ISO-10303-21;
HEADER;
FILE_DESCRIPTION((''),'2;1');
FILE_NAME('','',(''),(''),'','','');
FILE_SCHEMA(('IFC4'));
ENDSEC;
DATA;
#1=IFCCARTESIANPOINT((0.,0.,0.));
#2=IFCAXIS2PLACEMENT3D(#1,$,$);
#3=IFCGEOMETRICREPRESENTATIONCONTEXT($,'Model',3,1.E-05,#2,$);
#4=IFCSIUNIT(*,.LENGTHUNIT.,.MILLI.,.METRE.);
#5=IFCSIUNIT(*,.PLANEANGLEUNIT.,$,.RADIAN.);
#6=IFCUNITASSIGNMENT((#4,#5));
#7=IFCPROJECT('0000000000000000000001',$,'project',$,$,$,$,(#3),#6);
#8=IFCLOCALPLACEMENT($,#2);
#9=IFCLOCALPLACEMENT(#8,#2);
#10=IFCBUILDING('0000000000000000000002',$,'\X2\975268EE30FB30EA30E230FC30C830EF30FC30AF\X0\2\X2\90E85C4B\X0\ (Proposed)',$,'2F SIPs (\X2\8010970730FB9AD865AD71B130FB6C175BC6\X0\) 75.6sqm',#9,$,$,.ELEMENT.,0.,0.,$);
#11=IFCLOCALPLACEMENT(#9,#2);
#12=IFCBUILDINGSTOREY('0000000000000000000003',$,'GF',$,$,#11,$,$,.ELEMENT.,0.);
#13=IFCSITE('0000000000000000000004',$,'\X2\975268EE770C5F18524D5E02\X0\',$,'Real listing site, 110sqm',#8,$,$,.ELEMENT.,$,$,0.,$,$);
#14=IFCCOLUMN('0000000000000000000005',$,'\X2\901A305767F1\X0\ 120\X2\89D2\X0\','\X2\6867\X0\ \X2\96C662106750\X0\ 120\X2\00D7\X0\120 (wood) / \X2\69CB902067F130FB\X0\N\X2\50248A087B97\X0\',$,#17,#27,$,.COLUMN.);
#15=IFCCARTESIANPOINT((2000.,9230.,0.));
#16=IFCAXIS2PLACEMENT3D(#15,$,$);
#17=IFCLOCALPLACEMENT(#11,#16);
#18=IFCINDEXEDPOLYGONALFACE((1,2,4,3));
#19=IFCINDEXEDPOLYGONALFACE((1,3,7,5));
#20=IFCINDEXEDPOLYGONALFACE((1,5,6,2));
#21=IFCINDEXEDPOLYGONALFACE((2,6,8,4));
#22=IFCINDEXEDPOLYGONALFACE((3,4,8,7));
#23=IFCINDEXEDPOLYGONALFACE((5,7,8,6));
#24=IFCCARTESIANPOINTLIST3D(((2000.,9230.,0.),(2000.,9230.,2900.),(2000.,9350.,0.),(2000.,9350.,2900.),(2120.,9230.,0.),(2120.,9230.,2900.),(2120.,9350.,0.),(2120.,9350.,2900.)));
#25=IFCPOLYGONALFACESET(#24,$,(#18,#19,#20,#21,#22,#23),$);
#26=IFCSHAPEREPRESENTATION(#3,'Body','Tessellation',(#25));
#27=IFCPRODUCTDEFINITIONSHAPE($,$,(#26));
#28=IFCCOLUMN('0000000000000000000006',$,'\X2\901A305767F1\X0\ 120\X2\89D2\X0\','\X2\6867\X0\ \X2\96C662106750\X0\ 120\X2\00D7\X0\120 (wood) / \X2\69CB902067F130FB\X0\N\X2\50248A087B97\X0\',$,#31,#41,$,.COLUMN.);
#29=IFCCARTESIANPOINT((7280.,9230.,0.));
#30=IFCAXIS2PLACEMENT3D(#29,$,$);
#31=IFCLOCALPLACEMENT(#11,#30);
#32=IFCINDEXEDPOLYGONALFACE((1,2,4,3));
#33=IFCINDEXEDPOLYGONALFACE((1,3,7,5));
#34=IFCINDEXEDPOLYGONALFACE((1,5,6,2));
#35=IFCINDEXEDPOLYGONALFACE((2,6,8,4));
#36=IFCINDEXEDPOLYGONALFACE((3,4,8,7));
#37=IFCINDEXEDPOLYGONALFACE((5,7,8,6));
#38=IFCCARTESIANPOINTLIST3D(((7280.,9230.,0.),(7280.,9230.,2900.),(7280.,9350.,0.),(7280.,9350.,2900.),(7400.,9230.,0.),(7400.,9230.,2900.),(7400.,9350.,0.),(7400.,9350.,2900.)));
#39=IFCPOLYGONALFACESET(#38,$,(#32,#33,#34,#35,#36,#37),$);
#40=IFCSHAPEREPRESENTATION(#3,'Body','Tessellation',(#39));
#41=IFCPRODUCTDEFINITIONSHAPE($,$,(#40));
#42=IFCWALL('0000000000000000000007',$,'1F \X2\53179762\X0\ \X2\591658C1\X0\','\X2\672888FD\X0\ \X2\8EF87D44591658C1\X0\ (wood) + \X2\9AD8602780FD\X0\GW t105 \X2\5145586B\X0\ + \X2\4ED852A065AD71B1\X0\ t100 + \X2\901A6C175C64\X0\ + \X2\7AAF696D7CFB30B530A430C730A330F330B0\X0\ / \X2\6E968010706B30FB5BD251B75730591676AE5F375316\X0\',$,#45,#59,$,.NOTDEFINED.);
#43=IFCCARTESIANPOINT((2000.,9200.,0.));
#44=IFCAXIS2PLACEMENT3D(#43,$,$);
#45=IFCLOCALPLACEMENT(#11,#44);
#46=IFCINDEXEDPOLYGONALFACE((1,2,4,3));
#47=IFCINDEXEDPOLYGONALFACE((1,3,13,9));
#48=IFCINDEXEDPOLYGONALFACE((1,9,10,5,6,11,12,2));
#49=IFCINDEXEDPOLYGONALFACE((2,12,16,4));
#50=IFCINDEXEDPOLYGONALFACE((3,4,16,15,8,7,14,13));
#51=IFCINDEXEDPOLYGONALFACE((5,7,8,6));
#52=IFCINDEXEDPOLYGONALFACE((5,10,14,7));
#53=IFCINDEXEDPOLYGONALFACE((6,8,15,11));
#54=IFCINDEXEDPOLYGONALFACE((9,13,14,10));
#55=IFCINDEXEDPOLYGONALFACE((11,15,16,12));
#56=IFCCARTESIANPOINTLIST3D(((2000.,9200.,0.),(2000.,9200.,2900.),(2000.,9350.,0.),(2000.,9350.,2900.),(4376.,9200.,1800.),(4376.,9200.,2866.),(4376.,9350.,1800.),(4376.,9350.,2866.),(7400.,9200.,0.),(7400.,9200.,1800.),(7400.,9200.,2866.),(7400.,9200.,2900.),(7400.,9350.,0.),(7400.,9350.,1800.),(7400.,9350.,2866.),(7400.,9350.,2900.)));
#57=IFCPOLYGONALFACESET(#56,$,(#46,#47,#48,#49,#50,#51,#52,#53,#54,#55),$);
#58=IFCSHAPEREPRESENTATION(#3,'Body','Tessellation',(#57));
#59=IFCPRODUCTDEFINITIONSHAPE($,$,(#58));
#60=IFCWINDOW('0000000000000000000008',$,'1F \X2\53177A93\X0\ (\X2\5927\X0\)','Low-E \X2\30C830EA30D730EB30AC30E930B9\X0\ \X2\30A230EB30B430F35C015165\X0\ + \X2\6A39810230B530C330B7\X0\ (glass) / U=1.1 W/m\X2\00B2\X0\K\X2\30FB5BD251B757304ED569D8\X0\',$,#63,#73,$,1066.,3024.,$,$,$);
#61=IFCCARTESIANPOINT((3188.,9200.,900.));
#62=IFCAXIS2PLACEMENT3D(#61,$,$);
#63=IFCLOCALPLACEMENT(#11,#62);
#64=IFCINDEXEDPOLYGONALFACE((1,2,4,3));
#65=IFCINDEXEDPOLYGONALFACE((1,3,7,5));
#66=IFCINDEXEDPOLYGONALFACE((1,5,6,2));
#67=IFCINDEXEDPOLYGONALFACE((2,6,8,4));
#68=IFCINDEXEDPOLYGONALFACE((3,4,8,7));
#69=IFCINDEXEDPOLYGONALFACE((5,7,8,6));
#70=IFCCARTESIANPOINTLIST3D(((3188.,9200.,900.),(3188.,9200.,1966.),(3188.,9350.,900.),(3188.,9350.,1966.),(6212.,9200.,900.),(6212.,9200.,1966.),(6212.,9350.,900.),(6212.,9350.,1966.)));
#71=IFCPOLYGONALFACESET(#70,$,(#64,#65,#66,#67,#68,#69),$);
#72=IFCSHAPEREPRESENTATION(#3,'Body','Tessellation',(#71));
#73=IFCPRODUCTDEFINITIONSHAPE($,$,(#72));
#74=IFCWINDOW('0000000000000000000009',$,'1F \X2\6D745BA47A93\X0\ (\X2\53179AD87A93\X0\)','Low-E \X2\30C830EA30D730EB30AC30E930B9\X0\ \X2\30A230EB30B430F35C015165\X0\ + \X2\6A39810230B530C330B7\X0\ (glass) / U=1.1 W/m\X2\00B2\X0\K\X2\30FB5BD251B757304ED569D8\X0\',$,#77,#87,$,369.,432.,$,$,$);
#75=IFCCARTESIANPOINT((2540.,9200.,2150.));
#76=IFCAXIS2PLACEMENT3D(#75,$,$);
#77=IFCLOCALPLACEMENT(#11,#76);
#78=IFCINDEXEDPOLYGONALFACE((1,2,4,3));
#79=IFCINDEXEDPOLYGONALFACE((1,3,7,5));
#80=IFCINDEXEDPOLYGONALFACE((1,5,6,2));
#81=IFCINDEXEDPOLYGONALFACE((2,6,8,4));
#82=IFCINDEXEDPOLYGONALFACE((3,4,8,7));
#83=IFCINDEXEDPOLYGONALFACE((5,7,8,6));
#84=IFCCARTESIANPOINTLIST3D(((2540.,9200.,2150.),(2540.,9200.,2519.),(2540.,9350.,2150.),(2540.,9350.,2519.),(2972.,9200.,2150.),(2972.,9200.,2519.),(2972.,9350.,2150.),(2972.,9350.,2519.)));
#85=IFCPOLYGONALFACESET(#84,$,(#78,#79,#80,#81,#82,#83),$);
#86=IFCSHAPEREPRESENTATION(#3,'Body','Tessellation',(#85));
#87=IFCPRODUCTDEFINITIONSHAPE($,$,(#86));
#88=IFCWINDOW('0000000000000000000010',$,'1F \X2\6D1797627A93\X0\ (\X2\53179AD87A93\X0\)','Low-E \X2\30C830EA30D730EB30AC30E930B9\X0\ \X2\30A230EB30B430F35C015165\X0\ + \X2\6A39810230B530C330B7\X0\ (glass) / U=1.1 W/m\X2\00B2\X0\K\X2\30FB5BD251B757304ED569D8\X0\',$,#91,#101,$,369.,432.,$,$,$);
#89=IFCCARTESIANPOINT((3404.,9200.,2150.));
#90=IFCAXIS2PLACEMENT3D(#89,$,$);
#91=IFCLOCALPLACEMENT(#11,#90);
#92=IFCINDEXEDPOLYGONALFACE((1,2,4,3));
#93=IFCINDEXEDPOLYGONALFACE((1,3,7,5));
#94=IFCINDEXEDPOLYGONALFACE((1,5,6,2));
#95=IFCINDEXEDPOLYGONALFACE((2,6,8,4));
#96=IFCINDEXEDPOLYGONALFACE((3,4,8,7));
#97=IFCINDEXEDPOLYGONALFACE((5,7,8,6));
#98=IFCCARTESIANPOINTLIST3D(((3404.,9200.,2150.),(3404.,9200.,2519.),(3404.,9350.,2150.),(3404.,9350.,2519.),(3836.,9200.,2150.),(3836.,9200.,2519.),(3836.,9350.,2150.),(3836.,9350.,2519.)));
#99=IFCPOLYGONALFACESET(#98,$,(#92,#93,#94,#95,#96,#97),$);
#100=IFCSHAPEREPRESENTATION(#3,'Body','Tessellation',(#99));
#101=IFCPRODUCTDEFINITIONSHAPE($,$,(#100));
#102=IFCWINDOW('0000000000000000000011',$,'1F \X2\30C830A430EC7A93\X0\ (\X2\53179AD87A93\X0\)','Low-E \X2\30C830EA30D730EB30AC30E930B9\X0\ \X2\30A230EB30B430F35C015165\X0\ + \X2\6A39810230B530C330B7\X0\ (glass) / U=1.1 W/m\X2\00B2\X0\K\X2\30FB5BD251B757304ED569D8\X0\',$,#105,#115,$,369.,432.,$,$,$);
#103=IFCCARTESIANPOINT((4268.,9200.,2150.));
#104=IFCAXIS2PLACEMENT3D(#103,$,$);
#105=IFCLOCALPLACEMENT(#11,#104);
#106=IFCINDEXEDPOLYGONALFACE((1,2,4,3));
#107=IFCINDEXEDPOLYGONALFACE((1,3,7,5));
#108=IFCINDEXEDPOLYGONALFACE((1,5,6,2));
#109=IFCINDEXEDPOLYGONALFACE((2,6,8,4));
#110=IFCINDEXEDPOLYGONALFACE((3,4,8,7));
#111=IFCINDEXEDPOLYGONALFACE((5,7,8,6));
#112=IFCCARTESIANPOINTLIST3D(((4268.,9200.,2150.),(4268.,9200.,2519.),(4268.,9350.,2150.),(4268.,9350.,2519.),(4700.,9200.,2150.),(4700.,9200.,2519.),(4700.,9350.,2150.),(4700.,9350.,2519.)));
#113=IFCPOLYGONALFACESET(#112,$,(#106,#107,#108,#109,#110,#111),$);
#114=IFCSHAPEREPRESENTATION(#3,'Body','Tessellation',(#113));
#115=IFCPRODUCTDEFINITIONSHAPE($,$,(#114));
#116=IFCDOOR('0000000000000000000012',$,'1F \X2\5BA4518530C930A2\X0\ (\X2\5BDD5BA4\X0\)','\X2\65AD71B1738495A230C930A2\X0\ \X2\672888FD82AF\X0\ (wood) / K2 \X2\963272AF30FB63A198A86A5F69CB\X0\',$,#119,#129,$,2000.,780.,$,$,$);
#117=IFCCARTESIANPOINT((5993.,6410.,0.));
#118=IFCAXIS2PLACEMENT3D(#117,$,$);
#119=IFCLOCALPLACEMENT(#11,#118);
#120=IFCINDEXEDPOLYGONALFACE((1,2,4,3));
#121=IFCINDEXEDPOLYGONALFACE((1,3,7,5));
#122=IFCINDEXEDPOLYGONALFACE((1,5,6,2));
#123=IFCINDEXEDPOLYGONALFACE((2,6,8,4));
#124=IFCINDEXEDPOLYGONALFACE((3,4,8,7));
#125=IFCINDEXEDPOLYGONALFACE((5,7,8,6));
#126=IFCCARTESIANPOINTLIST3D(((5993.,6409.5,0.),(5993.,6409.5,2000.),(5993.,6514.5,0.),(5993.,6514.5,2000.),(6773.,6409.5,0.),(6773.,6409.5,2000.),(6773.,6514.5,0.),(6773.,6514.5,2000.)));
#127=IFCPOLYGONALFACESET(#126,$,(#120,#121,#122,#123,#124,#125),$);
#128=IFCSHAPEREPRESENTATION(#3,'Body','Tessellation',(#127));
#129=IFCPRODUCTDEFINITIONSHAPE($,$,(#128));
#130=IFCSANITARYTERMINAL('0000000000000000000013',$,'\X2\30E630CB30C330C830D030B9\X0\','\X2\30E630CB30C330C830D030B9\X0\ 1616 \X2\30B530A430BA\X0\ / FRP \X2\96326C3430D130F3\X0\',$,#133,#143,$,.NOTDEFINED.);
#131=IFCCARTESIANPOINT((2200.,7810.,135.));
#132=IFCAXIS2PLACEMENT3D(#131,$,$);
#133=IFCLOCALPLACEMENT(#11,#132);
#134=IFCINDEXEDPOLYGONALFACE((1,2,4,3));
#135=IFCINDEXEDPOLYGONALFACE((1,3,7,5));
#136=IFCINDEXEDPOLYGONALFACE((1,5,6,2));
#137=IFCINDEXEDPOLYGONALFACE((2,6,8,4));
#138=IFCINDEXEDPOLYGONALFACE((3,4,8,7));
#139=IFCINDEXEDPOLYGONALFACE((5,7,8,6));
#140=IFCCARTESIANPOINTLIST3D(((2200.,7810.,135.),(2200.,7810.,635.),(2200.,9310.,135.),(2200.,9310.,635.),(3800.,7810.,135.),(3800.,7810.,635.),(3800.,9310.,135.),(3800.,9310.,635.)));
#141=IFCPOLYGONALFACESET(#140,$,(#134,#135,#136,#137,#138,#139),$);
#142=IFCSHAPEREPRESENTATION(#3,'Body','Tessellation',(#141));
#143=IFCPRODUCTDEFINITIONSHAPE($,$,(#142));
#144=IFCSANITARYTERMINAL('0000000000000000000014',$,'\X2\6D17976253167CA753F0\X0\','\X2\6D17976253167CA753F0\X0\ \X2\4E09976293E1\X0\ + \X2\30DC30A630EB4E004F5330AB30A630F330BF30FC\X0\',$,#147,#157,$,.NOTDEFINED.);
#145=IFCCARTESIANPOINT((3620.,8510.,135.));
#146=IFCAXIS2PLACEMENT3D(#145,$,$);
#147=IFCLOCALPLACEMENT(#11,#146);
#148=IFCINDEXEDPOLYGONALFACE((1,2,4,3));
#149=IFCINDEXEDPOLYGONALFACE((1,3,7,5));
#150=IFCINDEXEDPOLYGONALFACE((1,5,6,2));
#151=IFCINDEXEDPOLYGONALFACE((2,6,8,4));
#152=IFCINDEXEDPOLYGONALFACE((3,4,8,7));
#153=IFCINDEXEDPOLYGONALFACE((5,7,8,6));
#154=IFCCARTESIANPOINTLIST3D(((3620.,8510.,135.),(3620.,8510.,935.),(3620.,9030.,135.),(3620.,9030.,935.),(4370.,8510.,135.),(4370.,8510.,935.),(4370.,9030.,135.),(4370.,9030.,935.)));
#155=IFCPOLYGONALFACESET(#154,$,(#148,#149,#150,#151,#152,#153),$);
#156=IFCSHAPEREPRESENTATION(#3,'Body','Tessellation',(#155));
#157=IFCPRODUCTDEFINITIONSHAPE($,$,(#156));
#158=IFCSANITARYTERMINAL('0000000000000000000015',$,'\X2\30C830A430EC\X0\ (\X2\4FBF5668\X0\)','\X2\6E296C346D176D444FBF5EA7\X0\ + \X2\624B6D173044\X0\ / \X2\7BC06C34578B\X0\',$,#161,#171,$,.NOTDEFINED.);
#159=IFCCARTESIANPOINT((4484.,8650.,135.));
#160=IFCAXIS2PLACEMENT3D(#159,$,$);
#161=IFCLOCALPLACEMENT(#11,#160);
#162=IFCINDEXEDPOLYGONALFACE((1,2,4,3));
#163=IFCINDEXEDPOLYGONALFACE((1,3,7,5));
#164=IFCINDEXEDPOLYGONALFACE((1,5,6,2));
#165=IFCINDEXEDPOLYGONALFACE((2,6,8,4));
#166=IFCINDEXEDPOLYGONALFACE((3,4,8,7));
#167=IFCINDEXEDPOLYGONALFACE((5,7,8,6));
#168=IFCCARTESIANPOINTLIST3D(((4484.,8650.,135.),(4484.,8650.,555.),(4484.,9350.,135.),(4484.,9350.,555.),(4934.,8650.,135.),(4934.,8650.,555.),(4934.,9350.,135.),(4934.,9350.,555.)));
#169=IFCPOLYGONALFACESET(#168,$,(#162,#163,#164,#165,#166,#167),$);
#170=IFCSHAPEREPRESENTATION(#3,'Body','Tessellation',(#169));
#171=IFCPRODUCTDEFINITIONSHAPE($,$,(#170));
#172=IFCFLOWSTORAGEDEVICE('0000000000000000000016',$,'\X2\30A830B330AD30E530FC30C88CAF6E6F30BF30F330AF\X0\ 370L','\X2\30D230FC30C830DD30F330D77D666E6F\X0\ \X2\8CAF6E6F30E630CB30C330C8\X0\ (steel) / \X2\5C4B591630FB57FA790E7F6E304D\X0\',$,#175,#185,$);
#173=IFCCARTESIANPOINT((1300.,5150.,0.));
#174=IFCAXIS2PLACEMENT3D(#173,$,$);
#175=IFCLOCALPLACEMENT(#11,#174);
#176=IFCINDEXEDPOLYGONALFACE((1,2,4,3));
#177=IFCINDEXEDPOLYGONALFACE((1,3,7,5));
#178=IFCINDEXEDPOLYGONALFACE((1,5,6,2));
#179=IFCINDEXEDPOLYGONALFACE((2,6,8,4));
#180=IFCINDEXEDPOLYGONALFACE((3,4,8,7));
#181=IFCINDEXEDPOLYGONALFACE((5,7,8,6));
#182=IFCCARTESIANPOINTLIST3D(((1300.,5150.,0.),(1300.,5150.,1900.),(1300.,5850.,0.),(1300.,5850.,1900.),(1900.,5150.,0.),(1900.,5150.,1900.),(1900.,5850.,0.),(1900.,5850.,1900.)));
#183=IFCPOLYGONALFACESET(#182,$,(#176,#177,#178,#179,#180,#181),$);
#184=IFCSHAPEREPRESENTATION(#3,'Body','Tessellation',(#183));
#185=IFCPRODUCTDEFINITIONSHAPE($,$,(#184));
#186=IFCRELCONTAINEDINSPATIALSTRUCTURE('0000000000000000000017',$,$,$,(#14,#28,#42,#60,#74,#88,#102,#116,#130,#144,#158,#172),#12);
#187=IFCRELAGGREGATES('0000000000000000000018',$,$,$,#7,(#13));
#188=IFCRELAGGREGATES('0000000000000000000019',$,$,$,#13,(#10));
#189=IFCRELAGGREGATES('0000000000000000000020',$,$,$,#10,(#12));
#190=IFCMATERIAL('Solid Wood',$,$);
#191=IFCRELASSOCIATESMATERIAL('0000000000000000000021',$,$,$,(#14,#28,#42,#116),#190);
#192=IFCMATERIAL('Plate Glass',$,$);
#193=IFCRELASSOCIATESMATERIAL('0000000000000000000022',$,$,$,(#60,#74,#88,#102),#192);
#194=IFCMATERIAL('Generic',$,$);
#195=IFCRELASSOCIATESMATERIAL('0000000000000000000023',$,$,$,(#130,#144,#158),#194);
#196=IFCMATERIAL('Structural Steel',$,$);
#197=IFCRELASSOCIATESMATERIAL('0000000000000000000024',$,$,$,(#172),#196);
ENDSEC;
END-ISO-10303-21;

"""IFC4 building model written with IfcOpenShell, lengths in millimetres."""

from ifc_helpers import new_model, si_unit, frame, frame_2d, origin, place, context, project, spatial, rectangle, extrude, material, element, fill, save


model = new_model("IFC4")

# Units and contexts
model_context = context("Model", 3, precision=1e-05, world=origin())
ifc_project = project(units=[si_unit("LENGTHUNIT", "METRE", prefix="MILLI"), si_unit("PLANEANGLEUNIT", "RADIAN")], contexts=[model_context])

# Site, building, storey
site_placement = place(None, origin())
site = spatial("IfcSite", under=ifc_project, at=site_placement, Name="青森県弘前市", ObjectType="Real listing site, 110sqm", CompositionType="ELEMENT", RefElevation=0.0)
building_placement = place(site_placement, origin())
building = spatial("IfcBuilding", under=site, at=building_placement, Name="青森・リモートワーク2部屋 (Proposed)", ObjectType="2F SIPs (耐震・高断熱・気密) 75.6sqm", CompositionType="ELEMENT", ElevationOfRefHeight=0.0, ElevationOfTerrain=0.0)
storey_placement = place(building_placement, origin())
storey = spatial("IfcBuildingStorey", under=building, at=storey_placement, Name="GF", CompositionType="ELEMENT", Elevation=0.0)

# Columns
ifc_material_1 = material(Name="Solid Wood")
column_1_placement = place(storey_placement, frame((2000.0, 9230.0, 0.0)))
element("IfcColumn", 1, at=column_1_placement, inside=storey, material=ifc_material_1, Name="通し柱 120角", Description="桧 集成材 120×120 (wood) / 構造柱・N値計算", PredefinedType="COLUMN", context=model_context, shape_type="SweptSolid", body=[
    extrude(rectangle(XDim=120.0, YDim=120.0, at=frame_2d((60.0, 60.0))), frame((2000.0, 9230.0, 0.0)), (0.0, 0.0, 1.0), 2900.0),
])
column_2_placement = place(storey_placement, frame((7280.0, 9230.0, 0.0)))
element("IfcColumn", 2, at=column_2_placement, inside=storey, material=ifc_material_1, Name="通し柱 120角", Description="桧 集成材 120×120 (wood) / 構造柱・N値計算", PredefinedType="COLUMN", context=model_context, shape_type="SweptSolid", body=[
    extrude(rectangle(XDim=120.0, YDim=120.0, at=frame_2d((60.0, 60.0))), frame((7280.0, 9230.0, 0.0)), (0.0, 0.0, 1.0), 2900.0),
])

# Wall, openings, windows
wall_1_placement = place(storey_placement, frame((2000.0, 9200.0, 0.0)))
wall_1 = element("IfcWall", 3, at=wall_1_placement, inside=storey, material=ifc_material_1, Name="1F 北面 外壁", Description="木製 軸組外壁 (wood) + 高性能GW t105 充填 + 付加断熱 t100 + 通気層 + 窯業系サイディング / 準耐火・寒冷地外皮強化", PredefinedType="NOTDEFINED", context=model_context, shape_type="SweptSolid", body=[
    extrude(rectangle(XDim=5400.0, YDim=150.0, at=frame_2d((2700.0, 75.0))), frame((2000.0, 9200.0, 0.0)), (0.0, 0.0, 1.0), 2900.0),
])
opening_1_placement = place(storey_placement, frame((3188.0, 9200.0, 900.0)))
opening_1 = element("IfcOpeningElement", 4, at=opening_1_placement, cuts=wall_1, PredefinedType="NOTDEFINED", context=model_context, shape_type="SweptSolid", body=[
    extrude(rectangle(XDim=3024.0, YDim=150.0, at=frame_2d((1512.0, 75.0))), frame((3188.0, 9200.0, 900.0)), (0.0, 0.0, 1.0), 1066.0),
])
opening_2_placement = place(storey_placement, frame((2540.0, 9200.0, 2150.0)))
opening_2 = element("IfcOpeningElement", 5, at=opening_2_placement, cuts=wall_1, PredefinedType="NOTDEFINED", context=model_context, shape_type="SweptSolid", body=[
    extrude(rectangle(XDim=432.0, YDim=150.0, at=frame_2d((216.0, 75.0))), frame((2540.0, 9200.0, 2150.0)), (0.0, 0.0, 1.0), 369.0),
])
opening_3_placement = place(storey_placement, frame((3404.0, 9200.0, 2150.0)))
opening_3 = element("IfcOpeningElement", 6, at=opening_3_placement, cuts=wall_1, PredefinedType="NOTDEFINED", context=model_context, shape_type="SweptSolid", body=[
    extrude(rectangle(XDim=432.0, YDim=150.0, at=frame_2d((216.0, 75.0))), frame((3404.0, 9200.0, 2150.0)), (0.0, 0.0, 1.0), 369.0),
])
opening_4_placement = place(storey_placement, frame((4268.0, 9200.0, 2150.0)))
opening_4 = element("IfcOpeningElement", 7, at=opening_4_placement, cuts=wall_1, PredefinedType="NOTDEFINED", context=model_context, shape_type="SweptSolid", body=[
    extrude(rectangle(XDim=432.0, YDim=150.0, at=frame_2d((216.0, 75.0))), frame((4268.0, 9200.0, 2150.0)), (0.0, 0.0, 1.0), 369.0),
])
ifc_material_2 = material(Name="Plate Glass")
window_1_placement = place(storey_placement, frame((3188.0, 9200.0, 900.0)))
window_1 = element("IfcWindow", 8, at=window_1_placement, inside=storey, material=ifc_material_2, Name="1F 北窓 (大)", Description="Low-E トリプルガラス アルゴン封入 + 樹脂サッシ (glass) / U=1.1 W/m²K・寒冷地仕様", OverallHeight=1066.0, OverallWidth=3024.0, context=model_context, shape_type="SweptSolid", body=[
    extrude(rectangle(XDim=3024.0, YDim=150.0, at=frame_2d((1512.0, 75.0))), frame((3188.0, 9200.0, 900.0)), (0.0, 0.0, 1.0), 1066.0),
])
fill(opening_1, window_1)
window_2_placement = place(storey_placement, frame((2540.0, 9200.0, 2150.0)))
window_2 = element("IfcWindow", 9, at=window_2_placement, inside=storey, material=ifc_material_2, Name="1F 浴室窓 (北高窓)", Description="Low-E トリプルガラス アルゴン封入 + 樹脂サッシ (glass) / U=1.1 W/m²K・寒冷地仕様", OverallHeight=369.0, OverallWidth=432.0, context=model_context, shape_type="SweptSolid", body=[
    extrude(rectangle(XDim=432.0, YDim=150.0, at=frame_2d((216.0, 75.0))), frame((2540.0, 9200.0, 2150.0)), (0.0, 0.0, 1.0), 369.0),
])
fill(opening_2, window_2)
window_3_placement = place(storey_placement, frame((3404.0, 9200.0, 2150.0)))
window_3 = element("IfcWindow", 10, at=window_3_placement, inside=storey, material=ifc_material_2, Name="1F 洗面窓 (北高窓)", Description="Low-E トリプルガラス アルゴン封入 + 樹脂サッシ (glass) / U=1.1 W/m²K・寒冷地仕様", OverallHeight=369.0, OverallWidth=432.0, context=model_context, shape_type="SweptSolid", body=[
    extrude(rectangle(XDim=432.0, YDim=150.0, at=frame_2d((216.0, 75.0))), frame((3404.0, 9200.0, 2150.0)), (0.0, 0.0, 1.0), 369.0),
])
fill(opening_3, window_3)
window_4_placement = place(storey_placement, frame((4268.0, 9200.0, 2150.0)))
window_4 = element("IfcWindow", 11, at=window_4_placement, inside=storey, material=ifc_material_2, Name="1F トイレ窓 (北高窓)", Description="Low-E トリプルガラス アルゴン封入 + 樹脂サッシ (glass) / U=1.1 W/m²K・寒冷地仕様", OverallHeight=369.0, OverallWidth=432.0, context=model_context, shape_type="SweptSolid", body=[
    extrude(rectangle(XDim=432.0, YDim=150.0, at=frame_2d((216.0, 75.0))), frame((4268.0, 9200.0, 2150.0)), (0.0, 0.0, 1.0), 369.0),
])
fill(opening_4, window_4)

# Door
door_1_placement = place(storey_placement, frame((5993.0, 6410.0, 0.0)))
element("IfcDoor", 12, at=door_1_placement, inside=storey, material=ifc_material_1, Name="1F 室内ドア (寝室)", Description="断熱玄関ドア 木製芯 (wood) / K2 防犯・採風機構", OverallHeight=2000.0, OverallWidth=780.0, context=model_context, shape_type="SweptSolid", body=[
    extrude(rectangle(XDim=780.0, YDim=105.0, at=frame_2d((390.0, 52.0))), frame((5993.0, 6410.0, 0.0)), (0.0, 0.0, 1.0), 2000.0),
])

# Sanitary terminals
ifc_material_3 = material(Name="Generic")
sanitary_terminal_1_placement = place(storey_placement, frame((2200.0, 7810.0, 135.0)))
element("IfcSanitaryTerminal", 13, at=sanitary_terminal_1_placement, inside=storey, material=ifc_material_3, Name="ユニットバス", Description="ユニットバス 1616 サイズ / FRP 防水パン", PredefinedType="NOTDEFINED", context=model_context, shape_type="SweptSolid", body=[
    extrude(rectangle(XDim=1600.0, YDim=1500.0, at=frame_2d((800.0, 750.0))), frame((2200.0, 7810.0, 135.0)), (0.0, 0.0, 1.0), 500.0),
])
sanitary_terminal_2_placement = place(storey_placement, frame((3620.0, 8510.0, 135.0)))
element("IfcSanitaryTerminal", 14, at=sanitary_terminal_2_placement, inside=storey, material=ifc_material_3, Name="洗面化粧台", Description="洗面化粧台 三面鏡 + ボウル一体カウンター", PredefinedType="NOTDEFINED", context=model_context, shape_type="SweptSolid", body=[
    extrude(rectangle(XDim=750.0, YDim=520.0, at=frame_2d((375.0, 260.0))), frame((3620.0, 8510.0, 135.0)), (0.0, 0.0, 1.0), 800.0),
])
sanitary_terminal_3_placement = place(storey_placement, frame((4484.0, 8650.0, 135.0)))
element("IfcSanitaryTerminal", 15, at=sanitary_terminal_3_placement, inside=storey, material=ifc_material_3, Name="トイレ (便器)", Description="温水洗浄便座 + 手洗い / 節水型", PredefinedType="NOTDEFINED", context=model_context, shape_type="SweptSolid", body=[
    extrude(rectangle(XDim=450.0, YDim=700.0, at=frame_2d((225.0, 350.0))), frame((4484.0, 8650.0, 135.0)), (0.0, 0.0, 1.0), 420.0),
])

# Flow storage device
ifc_material_4 = material(Name="Structural Steel")
flow_storage_device_placement = place(storey_placement, frame((1300.0, 5150.0, 0.0)))
element("IfcFlowStorageDevice", 16, at=flow_storage_device_placement, inside=storey, material=ifc_material_4, Name="エコキュート貯湯タンク 370L", Description="ヒートポンプ給湯 貯湯ユニット (steel) / 屋外・基礎置き", context=model_context, shape_type="SweptSolid", body=[
    extrude(rectangle(XDim=600.0, YDim=700.0, at=frame_2d((300.0, 350.0))), frame((1300.0, 5150.0, 0.0)), (0.0, 0.0, 1.0), 1900.0),
])

save(model, "model.ifc")
